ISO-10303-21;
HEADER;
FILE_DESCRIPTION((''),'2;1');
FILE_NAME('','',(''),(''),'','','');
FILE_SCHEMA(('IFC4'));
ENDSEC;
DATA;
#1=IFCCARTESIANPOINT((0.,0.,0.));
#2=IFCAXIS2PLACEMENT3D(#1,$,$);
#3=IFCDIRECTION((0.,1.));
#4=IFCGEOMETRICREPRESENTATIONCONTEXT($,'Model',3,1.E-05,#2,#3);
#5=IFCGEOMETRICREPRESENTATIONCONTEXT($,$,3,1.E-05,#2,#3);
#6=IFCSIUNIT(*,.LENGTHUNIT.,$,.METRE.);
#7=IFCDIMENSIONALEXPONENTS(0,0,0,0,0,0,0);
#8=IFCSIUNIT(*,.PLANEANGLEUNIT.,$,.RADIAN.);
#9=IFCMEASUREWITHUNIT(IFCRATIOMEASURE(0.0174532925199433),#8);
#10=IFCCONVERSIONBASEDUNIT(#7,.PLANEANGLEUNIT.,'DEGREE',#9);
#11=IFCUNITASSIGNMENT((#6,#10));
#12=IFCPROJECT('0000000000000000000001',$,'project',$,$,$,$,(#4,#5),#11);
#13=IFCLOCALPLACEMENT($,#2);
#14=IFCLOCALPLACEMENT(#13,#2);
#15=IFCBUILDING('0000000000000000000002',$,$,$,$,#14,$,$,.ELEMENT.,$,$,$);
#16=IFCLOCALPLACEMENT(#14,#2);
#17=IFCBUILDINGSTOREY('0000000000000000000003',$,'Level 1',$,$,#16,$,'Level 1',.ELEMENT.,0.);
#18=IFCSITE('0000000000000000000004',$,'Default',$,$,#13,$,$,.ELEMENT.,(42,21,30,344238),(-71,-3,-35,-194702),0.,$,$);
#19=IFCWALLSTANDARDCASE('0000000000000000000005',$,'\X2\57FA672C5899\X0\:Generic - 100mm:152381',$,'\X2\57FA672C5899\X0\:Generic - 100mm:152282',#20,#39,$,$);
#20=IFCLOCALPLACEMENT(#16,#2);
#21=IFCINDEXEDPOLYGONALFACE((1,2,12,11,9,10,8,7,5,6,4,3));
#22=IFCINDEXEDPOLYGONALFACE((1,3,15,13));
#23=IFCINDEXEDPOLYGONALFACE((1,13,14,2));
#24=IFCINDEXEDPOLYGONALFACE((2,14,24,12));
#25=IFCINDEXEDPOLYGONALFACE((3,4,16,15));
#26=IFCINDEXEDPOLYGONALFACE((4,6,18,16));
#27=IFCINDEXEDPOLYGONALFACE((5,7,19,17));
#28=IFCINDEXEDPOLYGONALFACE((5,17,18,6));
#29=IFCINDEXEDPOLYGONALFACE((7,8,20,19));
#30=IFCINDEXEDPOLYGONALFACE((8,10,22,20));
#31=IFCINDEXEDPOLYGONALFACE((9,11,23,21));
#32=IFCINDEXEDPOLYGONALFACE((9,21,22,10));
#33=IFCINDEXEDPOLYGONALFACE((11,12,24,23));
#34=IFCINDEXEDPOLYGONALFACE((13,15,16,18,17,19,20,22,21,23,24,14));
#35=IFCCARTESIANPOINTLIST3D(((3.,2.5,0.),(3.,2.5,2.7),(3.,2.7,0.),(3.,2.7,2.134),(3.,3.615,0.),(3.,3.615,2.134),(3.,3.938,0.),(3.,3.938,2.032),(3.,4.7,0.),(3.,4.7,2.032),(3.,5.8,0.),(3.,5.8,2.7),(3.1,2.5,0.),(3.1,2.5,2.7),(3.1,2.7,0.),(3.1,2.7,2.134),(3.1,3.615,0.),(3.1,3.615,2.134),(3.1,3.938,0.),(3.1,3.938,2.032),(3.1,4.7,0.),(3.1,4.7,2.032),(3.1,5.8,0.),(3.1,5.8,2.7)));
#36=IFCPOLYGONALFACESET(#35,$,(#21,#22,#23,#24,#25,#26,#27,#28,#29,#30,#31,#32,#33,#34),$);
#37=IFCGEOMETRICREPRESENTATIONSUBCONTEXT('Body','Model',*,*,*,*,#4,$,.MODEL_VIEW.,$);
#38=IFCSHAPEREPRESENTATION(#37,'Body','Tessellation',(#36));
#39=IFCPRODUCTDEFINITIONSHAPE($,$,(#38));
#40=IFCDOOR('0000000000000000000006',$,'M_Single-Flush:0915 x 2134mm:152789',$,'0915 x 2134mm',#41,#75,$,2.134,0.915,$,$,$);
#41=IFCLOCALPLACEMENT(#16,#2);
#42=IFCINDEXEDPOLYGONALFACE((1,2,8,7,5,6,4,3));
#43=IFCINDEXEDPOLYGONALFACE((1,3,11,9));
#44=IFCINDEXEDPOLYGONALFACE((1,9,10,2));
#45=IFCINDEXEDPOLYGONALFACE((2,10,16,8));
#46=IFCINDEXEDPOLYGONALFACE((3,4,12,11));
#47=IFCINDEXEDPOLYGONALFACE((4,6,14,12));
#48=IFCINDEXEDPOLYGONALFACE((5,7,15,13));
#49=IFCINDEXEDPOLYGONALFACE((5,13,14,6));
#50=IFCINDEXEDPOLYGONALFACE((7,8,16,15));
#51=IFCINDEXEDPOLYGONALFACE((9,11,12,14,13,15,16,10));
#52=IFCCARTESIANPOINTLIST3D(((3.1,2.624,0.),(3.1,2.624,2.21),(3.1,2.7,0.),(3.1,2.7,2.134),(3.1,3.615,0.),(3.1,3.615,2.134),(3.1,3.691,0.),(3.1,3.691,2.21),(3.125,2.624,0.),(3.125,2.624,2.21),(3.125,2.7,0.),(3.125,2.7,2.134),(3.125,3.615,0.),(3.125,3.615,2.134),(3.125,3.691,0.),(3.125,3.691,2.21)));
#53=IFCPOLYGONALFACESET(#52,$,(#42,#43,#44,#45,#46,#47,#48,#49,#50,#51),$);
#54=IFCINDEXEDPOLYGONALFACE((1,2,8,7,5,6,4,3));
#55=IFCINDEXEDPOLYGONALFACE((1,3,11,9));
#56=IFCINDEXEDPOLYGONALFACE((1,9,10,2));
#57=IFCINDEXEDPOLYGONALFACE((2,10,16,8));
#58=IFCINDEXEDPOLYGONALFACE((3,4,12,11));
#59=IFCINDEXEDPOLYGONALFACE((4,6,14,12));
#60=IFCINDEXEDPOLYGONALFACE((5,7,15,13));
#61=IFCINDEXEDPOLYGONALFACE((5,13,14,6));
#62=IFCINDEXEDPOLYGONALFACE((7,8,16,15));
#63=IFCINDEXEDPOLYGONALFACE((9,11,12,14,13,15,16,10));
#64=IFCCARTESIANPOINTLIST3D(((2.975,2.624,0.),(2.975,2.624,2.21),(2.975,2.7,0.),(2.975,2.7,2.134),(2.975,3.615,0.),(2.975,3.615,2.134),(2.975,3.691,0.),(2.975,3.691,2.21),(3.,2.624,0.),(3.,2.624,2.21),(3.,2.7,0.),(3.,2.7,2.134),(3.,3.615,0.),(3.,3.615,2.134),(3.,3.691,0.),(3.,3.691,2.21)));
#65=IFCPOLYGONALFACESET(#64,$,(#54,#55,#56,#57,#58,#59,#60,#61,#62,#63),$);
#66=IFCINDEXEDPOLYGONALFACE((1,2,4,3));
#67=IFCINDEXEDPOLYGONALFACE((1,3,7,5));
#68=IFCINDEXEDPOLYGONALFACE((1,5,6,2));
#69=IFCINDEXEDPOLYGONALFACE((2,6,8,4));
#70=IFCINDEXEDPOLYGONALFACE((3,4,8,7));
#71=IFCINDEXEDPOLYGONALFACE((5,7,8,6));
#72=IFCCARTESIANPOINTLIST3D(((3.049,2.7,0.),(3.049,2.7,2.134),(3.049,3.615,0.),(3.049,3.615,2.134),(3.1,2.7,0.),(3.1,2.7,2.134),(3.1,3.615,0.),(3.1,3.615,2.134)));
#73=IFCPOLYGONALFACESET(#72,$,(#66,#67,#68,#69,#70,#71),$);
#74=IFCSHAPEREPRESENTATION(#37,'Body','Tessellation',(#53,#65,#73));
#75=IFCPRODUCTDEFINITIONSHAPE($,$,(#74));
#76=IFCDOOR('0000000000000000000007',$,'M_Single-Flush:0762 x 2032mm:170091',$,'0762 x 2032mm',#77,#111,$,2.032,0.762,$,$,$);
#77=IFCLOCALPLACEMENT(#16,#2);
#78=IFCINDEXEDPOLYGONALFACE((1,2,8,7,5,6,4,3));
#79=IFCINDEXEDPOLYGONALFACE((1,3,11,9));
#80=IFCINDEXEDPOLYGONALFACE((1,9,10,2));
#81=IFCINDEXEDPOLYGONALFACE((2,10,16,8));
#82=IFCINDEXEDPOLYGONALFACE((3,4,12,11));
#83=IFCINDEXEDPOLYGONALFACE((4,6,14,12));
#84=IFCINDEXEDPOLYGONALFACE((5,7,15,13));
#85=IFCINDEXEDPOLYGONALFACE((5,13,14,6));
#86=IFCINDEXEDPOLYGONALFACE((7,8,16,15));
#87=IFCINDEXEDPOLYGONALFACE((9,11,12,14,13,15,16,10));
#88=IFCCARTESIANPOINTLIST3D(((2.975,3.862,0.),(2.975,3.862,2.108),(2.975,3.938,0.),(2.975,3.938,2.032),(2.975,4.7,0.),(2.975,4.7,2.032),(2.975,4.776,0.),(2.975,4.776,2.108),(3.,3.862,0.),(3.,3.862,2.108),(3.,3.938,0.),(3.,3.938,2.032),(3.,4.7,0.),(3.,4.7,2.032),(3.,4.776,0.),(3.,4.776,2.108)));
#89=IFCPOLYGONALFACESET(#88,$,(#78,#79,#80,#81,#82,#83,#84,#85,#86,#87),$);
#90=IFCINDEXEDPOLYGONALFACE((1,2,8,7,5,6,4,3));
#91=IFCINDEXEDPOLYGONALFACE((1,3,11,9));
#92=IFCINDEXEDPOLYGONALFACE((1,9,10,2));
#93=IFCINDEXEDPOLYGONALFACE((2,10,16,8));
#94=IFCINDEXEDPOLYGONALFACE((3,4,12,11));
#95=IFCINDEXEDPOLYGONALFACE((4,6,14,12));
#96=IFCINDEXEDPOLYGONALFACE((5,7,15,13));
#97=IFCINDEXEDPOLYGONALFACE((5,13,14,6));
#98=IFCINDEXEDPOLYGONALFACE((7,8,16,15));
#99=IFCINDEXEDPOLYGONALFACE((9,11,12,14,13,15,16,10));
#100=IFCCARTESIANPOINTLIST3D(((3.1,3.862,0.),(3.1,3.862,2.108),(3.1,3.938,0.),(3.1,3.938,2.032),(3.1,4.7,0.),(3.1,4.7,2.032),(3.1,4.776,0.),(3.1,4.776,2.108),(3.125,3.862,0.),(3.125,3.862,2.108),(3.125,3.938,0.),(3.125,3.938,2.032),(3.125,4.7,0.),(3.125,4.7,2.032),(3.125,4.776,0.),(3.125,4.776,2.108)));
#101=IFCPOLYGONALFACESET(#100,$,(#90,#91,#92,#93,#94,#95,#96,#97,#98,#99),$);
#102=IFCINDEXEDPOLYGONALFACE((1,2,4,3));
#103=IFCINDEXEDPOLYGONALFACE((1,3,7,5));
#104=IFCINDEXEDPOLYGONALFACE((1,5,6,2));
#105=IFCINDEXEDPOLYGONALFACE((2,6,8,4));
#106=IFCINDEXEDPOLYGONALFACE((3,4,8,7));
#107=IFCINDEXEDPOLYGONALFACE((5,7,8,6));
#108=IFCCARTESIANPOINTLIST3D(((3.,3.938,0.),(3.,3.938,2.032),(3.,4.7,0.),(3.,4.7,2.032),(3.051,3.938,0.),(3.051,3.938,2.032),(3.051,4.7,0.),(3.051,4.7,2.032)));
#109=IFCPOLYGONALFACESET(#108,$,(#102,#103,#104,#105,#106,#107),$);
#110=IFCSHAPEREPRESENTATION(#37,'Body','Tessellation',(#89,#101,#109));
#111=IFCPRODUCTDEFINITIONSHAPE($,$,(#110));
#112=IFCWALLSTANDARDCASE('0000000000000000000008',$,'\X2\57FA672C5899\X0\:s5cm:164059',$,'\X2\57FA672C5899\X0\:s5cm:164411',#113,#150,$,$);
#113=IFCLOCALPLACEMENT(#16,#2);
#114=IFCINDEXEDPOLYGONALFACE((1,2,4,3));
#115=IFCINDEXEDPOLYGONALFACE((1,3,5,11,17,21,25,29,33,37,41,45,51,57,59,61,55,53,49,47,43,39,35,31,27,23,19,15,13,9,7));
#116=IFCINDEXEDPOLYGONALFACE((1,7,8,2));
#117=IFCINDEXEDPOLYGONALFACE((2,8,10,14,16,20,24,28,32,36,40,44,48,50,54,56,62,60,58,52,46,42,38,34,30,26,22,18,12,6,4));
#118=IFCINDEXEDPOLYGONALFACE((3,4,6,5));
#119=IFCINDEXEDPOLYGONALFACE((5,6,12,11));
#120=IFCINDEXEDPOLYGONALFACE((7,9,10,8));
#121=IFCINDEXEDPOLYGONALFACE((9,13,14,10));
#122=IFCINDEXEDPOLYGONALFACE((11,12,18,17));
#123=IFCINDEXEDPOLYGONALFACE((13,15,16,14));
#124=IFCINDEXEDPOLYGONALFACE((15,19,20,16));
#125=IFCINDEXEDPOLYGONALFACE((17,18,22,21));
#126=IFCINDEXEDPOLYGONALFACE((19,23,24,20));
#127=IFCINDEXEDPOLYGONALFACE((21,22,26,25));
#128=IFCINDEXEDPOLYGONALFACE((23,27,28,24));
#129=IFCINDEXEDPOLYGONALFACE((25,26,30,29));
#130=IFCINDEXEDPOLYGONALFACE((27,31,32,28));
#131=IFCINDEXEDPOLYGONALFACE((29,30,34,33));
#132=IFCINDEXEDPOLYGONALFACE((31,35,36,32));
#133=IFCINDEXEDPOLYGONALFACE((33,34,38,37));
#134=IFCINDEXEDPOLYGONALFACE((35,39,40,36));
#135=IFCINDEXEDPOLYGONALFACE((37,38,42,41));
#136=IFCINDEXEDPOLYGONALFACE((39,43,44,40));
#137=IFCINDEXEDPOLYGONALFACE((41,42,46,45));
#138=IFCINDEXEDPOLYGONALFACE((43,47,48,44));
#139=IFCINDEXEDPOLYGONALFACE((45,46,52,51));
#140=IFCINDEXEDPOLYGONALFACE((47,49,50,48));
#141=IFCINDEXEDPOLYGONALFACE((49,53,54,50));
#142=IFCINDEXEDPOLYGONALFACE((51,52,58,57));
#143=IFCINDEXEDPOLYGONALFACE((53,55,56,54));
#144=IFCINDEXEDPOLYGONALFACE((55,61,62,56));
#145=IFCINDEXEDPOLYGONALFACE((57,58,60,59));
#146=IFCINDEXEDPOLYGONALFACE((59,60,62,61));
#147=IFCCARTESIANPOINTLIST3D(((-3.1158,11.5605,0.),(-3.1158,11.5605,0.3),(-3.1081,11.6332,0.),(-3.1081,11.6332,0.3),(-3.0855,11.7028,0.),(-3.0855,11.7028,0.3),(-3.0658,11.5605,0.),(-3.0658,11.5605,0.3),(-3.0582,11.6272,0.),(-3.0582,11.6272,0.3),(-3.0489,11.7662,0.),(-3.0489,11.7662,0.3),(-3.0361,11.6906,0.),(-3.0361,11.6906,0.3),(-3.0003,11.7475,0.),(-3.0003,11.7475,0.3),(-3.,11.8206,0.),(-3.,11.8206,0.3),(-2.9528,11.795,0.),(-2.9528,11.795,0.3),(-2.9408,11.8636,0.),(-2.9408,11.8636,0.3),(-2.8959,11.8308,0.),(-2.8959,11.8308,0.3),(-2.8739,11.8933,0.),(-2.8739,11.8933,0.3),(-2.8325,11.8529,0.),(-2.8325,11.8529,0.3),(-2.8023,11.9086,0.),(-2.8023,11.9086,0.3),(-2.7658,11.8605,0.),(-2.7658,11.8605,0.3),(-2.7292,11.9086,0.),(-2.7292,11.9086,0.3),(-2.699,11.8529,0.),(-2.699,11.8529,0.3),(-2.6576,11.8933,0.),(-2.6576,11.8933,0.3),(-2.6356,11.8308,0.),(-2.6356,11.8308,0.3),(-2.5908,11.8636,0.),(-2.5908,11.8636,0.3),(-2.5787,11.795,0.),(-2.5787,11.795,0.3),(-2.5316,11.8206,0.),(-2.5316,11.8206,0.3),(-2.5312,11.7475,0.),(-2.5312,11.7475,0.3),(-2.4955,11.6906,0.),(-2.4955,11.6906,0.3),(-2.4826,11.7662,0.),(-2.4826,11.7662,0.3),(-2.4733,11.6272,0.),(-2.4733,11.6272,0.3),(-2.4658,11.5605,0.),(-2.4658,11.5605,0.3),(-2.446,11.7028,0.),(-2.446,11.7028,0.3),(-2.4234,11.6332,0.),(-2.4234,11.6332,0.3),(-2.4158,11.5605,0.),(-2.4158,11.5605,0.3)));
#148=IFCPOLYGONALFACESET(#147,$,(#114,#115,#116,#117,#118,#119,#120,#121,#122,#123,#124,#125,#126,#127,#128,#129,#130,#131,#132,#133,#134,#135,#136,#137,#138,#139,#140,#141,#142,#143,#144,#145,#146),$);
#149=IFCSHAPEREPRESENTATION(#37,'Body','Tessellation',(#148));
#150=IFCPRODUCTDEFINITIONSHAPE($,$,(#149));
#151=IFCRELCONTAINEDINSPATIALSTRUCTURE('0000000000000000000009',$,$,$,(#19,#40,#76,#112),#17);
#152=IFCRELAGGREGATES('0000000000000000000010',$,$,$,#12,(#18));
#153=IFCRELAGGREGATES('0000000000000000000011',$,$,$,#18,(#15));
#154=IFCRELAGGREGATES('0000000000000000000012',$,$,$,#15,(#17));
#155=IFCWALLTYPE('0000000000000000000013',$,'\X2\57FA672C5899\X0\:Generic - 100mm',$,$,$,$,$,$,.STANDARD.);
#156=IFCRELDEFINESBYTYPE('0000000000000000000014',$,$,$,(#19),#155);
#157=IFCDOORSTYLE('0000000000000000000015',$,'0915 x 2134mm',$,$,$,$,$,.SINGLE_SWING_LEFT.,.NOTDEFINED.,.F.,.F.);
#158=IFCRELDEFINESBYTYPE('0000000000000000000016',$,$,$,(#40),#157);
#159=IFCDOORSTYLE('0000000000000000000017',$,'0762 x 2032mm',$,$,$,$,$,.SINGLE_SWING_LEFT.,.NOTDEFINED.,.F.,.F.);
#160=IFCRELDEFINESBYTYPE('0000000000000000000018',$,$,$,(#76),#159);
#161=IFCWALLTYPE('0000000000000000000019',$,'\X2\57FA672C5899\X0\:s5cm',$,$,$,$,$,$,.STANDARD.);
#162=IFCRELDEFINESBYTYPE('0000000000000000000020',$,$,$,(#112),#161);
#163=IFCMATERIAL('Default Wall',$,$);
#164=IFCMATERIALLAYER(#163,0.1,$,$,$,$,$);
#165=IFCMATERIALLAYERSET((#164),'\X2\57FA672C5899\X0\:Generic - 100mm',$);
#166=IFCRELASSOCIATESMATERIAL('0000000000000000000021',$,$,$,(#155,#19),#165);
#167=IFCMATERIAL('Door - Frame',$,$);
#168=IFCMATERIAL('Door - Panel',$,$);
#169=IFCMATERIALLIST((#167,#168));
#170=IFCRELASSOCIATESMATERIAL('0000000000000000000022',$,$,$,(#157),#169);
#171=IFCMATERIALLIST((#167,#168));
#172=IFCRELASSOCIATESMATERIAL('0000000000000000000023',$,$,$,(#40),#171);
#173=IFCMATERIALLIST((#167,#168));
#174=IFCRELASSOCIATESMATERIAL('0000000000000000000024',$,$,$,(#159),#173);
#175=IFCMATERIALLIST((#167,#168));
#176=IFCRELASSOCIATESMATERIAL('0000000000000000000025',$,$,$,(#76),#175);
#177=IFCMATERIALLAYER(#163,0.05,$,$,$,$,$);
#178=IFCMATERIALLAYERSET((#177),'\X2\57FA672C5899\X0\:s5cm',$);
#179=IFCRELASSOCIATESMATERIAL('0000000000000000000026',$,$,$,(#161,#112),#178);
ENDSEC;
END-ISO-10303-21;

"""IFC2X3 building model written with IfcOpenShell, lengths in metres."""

from ifc_helpers import new_model, entity, si_unit, converted_unit, direction, frame, frame_2d, origin, origin_2d_with_axis, place, context, subcontext, project, spatial, polyline, circle_curve, parameter, trimmed, segment, composite_curve, rectangle, outline, extrude, clip, bounded_halfspace, source, transform, mapped, material, material_list, layer, layer_set, layer_usage, type_object, type_shapes, element, fill, save


model = new_model("IFC2X3")

# Units and contexts
model_context = context("Model", 3, precision=1e-05, world=origin(), true_north=direction((0.0, 1.0)))
context_of_model = context(None, 3, precision=1e-05, world=origin(), true_north=direction((0.0, 1.0)))
body_context = subcontext(model_context, "Body", "Model", "MODEL_VIEW")
ifc_project = project(units=[si_unit("LENGTHUNIT", "METRE"), converted_unit("PLANEANGLEUNIT", "DEGREE", entity("IfcRatioMeasure", 0.0174532925199433), si_unit("PLANEANGLEUNIT", "RADIAN"), dimensions=[0, 0, 0, 0, 0, 0, 0])], contexts=[model_context, context_of_model])

# Site, building, storey
site_placement = place(None, origin())
site = spatial("IfcSite", under=ifc_project, at=site_placement, Name="Default", CompositionType="ELEMENT", RefLatitude=(42, 21, 30, 344238), RefLongitude=(-71, -3, -35, -194702), RefElevation=0.0)
building_placement = place(site_placement, origin())
building = spatial("IfcBuilding", under=site, at=building_placement, CompositionType="ELEMENT")
storey_placement = place(building_placement, origin())
storey = spatial("IfcBuildingStorey", under=building, at=storey_placement, Name="Level 1", LongName="Level 1", CompositionType="ELEMENT", Elevation=0.0)

# Shared definitions
ifc_material_1 = material(Name="Default Wall")
ifc_layer_1 = layer(ifc_material_1, 0.1)
ifc_layer_set_1 = layer_set([ifc_layer_1], Name="基本墙:Generic - 100mm")
wall_type_1 = type_object("IfcWallType", Name="基本墙:Generic - 100mm", PredefinedType="STANDARD", material=ifc_layer_set_1)
ifc_material_2 = material(Name="Door - Frame")
ifc_material_3 = material(Name="Door - Panel")
ifc_material_list_1 = material_list([ifc_material_2, ifc_material_3])
door_style_1 = type_object("IfcDoorStyle", Name="0915 x 2134mm", ConstructionType="NOTDEFINED", OperationType="SINGLE_SWING_LEFT", ParameterTakesPrecedence=False, Sizeable=False, material=ifc_material_list_1)
shared_shape_1 = source(origin(), body_context, "Body", "SweptSolid", [
    extrude(outline(polyline([(-0.5335, -1.124), (0.5335, -1.124), (0.5335, 1.086), (0.4575, 1.086), (0.4575, -1.048), (-0.4575, -1.048), (-0.4575, 1.086), (-0.5335, 1.086), (-0.5335, -1.124)])), frame((0.4575, 0.125, 1.086), z_axis=(0.0, -1.0, 0.0), x_axis=(-1.0, 0.0, 0.0)), (0.0, 0.0, 1.0), 0.025),
    extrude(outline(polyline([(-1.124, -0.5335), (1.086, -0.5335), (1.086, -0.4575), (-1.048, -0.4575), (-1.048, 0.4575), (1.086, 0.4575), (1.086, 0.5335), (-1.124, 0.5335), (-1.124, -0.5335)])), frame((0.4575, 0.0, 1.086), z_axis=(0.0, -1.0, 0.0), x_axis=(0.0, 0.0, -1.0)), (0.0, 0.0, 1.0), 0.025),
    extrude(rectangle(XDim=0.915, YDim=0.051, at=origin_2d_with_axis()), frame((0.4575, 0.0745, 0.0)), (0.0, 0.0, 1.0), 2.134),
])
type_shapes(door_style_1, [shared_shape_1])

# Wall, openings, doors
ifc_layer_usage_1 = layer_usage(ifc_layer_set_1, "AXIS2", "NEGATIVE", 0.05)
wall_1_placement = place(storey_placement, frame((3.05, 2.5, 0.0), z_axis=(0.0, 0.0, 1.0), x_axis=(0.0, 1.0, 0.0)))
wall_1 = element("IfcWallStandardCase", 1, at=wall_1_placement, inside=storey, type_object=wall_type_1, material=ifc_layer_usage_1, Name="基本墙:Generic - 100mm:152381", ObjectType="基本墙:Generic - 100mm:152282", context=body_context, shape_type="Clipping", body=[
    clip(extrude(rectangle(XDim=3.3, YDim=0.1, at=frame_2d((1.65, 0.0), x_axis=(-1.0, 0.0))), origin(), (0.0, 0.0, 1.0), 2.7), bounded_halfspace(frame((0.0, -0.05, 2.7), z_axis=(0.0, 0.0, -1.0), x_axis=(-1.0, 0.0, 0.0)), True, frame((0.0, -0.05, 2.7)), polyline([(0.0, 0.0), (1.2, 0.0), (1.3, 0.0), (3.3, 0.0), (3.3, 0.1), (1.3, 0.1), (1.2, 0.1), (0.0, 0.1), (0.0, 0.0)]))),
])
opening_1_placement = place(wall_1_placement, frame((1.438, -0.05, 0.0)))
opening_1 = element("IfcOpeningElement", 2, at=opening_1_placement, cuts=wall_1, ObjectType="Opening", context=body_context, shape_type="SweptSolid", body=[
    extrude(rectangle(XDim=0.762, YDim=2.032, at=frame_2d((1.016, 0.381), x_axis=(0.0, -1.0))), frame((0.0, 0.0, 0.0), z_axis=(0.0, 1.0, 0.0), x_axis=(0.0, 0.0, 1.0)), (0.0, 0.0, 1.0), 0.1),
])
opening_2_placement = place(wall_1_placement, frame((1.115, 0.05, 0.0)))
opening_2 = element("IfcOpeningElement", 3, at=opening_2_placement, cuts=wall_1, ObjectType="Opening", context=body_context, shape_type="SweptSolid", body=[
    extrude(rectangle(XDim=0.915, YDim=2.134, at=frame_2d((1.067, 0.4575), x_axis=(0.0, -1.0))), frame((0.0, 0.0, 0.0), z_axis=(0.0, -1.0, 0.0), x_axis=(0.0, 0.0, 1.0)), (0.0, 0.0, 1.0), 0.1),
])
ifc_material_list_2 = material_list([ifc_material_2, ifc_material_3])
door_1_placement = place(opening_2_placement, frame((0.0, 0.0, 0.0), z_axis=(0.0, 0.0, 1.0), x_axis=(-1.0, 0.0, 0.0)))
door_1 = element("IfcDoor", 4, at=door_1_placement, inside=storey, type_object=door_style_1, material=ifc_material_list_2, Name="M_Single-Flush:0915 x 2134mm:152789", ObjectType="0915 x 2134mm", OverallHeight=2.134, OverallWidth=0.915, context=body_context, shape_type="MappedRepresentation", body=[
    mapped(shared_shape_1, transform((0.0, 0.0, 0.0), scale=1.0)),
])
fill(opening_2, door_1)
ifc_material_list_3 = material_list([ifc_material_2, ifc_material_3])
ifc_material_list_4 = material_list([ifc_material_2, ifc_material_3])
door_style_2 = type_object("IfcDoorStyle", Name="0762 x 2032mm", ConstructionType="NOTDEFINED", OperationType="SINGLE_SWING_LEFT", ParameterTakesPrecedence=False, Sizeable=False, material=ifc_material_list_4)
shared_shape_2 = source(origin(), body_context, "Body", "SweptSolid", [
    extrude(outline(polyline([(-0.457, -1.073), (0.457, -1.073), (0.457, 1.035), (0.381, 1.035), (0.381, -0.997), (-0.381, -0.997), (-0.381, 1.035), (-0.457, 1.035), (-0.457, -1.073)])), frame((0.381, 0.125, 1.035), z_axis=(0.0, -1.0, 0.0), x_axis=(-1.0, 0.0, 0.0)), (0.0, 0.0, 1.0), 0.025),
    extrude(outline(polyline([(-1.073, -0.457), (1.035, -0.457), (1.035, -0.381), (-0.997, -0.381), (-0.997, 0.381), (1.035, 0.381), (1.035, 0.457), (-1.073, 0.457), (-1.073, -0.457)])), frame((0.381, 0.0, 1.035), z_axis=(0.0, -1.0, 0.0), x_axis=(0.0, 0.0, -1.0)), (0.0, 0.0, 1.0), 0.025),
    extrude(rectangle(XDim=0.762, YDim=0.051, at=origin_2d_with_axis()), frame((0.381, 0.0745, 0.0)), (0.0, 0.0, 1.0), 2.032),
])
type_shapes(door_style_2, [shared_shape_2])
door_2_placement = place(opening_1_placement, origin())
door_2 = element("IfcDoor", 5, at=door_2_placement, inside=storey, type_object=door_style_2, material=ifc_material_list_3, Name="M_Single-Flush:0762 x 2032mm:170091", ObjectType="0762 x 2032mm", OverallHeight=2.032, OverallWidth=0.762, context=body_context, shape_type="MappedRepresentation", body=[
    mapped(shared_shape_2, transform((0.0, 0.0, 0.0), scale=1.0)),
])
fill(opening_1, door_2)

# Wall
ifc_layer_2 = layer(ifc_material_1, 0.05)
ifc_layer_set_2 = layer_set([ifc_layer_2], Name="基本墙:s5cm")
wall_type_2 = type_object("IfcWallType", Name="基本墙:s5cm", PredefinedType="STANDARD", material=ifc_layer_set_2)
ifc_layer_usage_2 = layer_usage(ifc_layer_set_2, "AXIS2", "POSITIVE", -0.025)
wall_2_placement = place(storey_placement, frame((-3.0908, 11.5605, 0.0)))
element("IfcWallStandardCase", 6, at=wall_2_placement, inside=storey, type_object=wall_type_2, material=ifc_layer_usage_2, Name="基本墙:s5cm:164059", ObjectType="基本墙:s5cm:164411", context=body_context, shape_type="SweptSolid", body=[
    extrude(outline(composite_curve([segment(trimmed(circle_curve(frame_2d((0.325, 0.0), x_axis=(1.0, 0.0)), 0.35), [parameter(0.0)], [parameter(180.0)], True, "PARAMETER"), True, "CONTINUOUS"), segment(polyline([(-0.025, 0.0), (0.025, 0.0)]), True, "CONTINUOUS"), segment(trimmed(circle_curve(frame_2d((0.325, 0.0), x_axis=(1.0, 0.0)), 0.3), [parameter(0.0)], [parameter(180.0)], True, "PARAMETER"), False, "CONTINUOUS"), segment(polyline([(0.625, 0.0), (0.675, 0.0)]), True, "CONTINUOUS")], self_intersect=False)), origin(), (0.0, 0.0, 1.0), 0.3),
])

save(model, "model.ifc")
